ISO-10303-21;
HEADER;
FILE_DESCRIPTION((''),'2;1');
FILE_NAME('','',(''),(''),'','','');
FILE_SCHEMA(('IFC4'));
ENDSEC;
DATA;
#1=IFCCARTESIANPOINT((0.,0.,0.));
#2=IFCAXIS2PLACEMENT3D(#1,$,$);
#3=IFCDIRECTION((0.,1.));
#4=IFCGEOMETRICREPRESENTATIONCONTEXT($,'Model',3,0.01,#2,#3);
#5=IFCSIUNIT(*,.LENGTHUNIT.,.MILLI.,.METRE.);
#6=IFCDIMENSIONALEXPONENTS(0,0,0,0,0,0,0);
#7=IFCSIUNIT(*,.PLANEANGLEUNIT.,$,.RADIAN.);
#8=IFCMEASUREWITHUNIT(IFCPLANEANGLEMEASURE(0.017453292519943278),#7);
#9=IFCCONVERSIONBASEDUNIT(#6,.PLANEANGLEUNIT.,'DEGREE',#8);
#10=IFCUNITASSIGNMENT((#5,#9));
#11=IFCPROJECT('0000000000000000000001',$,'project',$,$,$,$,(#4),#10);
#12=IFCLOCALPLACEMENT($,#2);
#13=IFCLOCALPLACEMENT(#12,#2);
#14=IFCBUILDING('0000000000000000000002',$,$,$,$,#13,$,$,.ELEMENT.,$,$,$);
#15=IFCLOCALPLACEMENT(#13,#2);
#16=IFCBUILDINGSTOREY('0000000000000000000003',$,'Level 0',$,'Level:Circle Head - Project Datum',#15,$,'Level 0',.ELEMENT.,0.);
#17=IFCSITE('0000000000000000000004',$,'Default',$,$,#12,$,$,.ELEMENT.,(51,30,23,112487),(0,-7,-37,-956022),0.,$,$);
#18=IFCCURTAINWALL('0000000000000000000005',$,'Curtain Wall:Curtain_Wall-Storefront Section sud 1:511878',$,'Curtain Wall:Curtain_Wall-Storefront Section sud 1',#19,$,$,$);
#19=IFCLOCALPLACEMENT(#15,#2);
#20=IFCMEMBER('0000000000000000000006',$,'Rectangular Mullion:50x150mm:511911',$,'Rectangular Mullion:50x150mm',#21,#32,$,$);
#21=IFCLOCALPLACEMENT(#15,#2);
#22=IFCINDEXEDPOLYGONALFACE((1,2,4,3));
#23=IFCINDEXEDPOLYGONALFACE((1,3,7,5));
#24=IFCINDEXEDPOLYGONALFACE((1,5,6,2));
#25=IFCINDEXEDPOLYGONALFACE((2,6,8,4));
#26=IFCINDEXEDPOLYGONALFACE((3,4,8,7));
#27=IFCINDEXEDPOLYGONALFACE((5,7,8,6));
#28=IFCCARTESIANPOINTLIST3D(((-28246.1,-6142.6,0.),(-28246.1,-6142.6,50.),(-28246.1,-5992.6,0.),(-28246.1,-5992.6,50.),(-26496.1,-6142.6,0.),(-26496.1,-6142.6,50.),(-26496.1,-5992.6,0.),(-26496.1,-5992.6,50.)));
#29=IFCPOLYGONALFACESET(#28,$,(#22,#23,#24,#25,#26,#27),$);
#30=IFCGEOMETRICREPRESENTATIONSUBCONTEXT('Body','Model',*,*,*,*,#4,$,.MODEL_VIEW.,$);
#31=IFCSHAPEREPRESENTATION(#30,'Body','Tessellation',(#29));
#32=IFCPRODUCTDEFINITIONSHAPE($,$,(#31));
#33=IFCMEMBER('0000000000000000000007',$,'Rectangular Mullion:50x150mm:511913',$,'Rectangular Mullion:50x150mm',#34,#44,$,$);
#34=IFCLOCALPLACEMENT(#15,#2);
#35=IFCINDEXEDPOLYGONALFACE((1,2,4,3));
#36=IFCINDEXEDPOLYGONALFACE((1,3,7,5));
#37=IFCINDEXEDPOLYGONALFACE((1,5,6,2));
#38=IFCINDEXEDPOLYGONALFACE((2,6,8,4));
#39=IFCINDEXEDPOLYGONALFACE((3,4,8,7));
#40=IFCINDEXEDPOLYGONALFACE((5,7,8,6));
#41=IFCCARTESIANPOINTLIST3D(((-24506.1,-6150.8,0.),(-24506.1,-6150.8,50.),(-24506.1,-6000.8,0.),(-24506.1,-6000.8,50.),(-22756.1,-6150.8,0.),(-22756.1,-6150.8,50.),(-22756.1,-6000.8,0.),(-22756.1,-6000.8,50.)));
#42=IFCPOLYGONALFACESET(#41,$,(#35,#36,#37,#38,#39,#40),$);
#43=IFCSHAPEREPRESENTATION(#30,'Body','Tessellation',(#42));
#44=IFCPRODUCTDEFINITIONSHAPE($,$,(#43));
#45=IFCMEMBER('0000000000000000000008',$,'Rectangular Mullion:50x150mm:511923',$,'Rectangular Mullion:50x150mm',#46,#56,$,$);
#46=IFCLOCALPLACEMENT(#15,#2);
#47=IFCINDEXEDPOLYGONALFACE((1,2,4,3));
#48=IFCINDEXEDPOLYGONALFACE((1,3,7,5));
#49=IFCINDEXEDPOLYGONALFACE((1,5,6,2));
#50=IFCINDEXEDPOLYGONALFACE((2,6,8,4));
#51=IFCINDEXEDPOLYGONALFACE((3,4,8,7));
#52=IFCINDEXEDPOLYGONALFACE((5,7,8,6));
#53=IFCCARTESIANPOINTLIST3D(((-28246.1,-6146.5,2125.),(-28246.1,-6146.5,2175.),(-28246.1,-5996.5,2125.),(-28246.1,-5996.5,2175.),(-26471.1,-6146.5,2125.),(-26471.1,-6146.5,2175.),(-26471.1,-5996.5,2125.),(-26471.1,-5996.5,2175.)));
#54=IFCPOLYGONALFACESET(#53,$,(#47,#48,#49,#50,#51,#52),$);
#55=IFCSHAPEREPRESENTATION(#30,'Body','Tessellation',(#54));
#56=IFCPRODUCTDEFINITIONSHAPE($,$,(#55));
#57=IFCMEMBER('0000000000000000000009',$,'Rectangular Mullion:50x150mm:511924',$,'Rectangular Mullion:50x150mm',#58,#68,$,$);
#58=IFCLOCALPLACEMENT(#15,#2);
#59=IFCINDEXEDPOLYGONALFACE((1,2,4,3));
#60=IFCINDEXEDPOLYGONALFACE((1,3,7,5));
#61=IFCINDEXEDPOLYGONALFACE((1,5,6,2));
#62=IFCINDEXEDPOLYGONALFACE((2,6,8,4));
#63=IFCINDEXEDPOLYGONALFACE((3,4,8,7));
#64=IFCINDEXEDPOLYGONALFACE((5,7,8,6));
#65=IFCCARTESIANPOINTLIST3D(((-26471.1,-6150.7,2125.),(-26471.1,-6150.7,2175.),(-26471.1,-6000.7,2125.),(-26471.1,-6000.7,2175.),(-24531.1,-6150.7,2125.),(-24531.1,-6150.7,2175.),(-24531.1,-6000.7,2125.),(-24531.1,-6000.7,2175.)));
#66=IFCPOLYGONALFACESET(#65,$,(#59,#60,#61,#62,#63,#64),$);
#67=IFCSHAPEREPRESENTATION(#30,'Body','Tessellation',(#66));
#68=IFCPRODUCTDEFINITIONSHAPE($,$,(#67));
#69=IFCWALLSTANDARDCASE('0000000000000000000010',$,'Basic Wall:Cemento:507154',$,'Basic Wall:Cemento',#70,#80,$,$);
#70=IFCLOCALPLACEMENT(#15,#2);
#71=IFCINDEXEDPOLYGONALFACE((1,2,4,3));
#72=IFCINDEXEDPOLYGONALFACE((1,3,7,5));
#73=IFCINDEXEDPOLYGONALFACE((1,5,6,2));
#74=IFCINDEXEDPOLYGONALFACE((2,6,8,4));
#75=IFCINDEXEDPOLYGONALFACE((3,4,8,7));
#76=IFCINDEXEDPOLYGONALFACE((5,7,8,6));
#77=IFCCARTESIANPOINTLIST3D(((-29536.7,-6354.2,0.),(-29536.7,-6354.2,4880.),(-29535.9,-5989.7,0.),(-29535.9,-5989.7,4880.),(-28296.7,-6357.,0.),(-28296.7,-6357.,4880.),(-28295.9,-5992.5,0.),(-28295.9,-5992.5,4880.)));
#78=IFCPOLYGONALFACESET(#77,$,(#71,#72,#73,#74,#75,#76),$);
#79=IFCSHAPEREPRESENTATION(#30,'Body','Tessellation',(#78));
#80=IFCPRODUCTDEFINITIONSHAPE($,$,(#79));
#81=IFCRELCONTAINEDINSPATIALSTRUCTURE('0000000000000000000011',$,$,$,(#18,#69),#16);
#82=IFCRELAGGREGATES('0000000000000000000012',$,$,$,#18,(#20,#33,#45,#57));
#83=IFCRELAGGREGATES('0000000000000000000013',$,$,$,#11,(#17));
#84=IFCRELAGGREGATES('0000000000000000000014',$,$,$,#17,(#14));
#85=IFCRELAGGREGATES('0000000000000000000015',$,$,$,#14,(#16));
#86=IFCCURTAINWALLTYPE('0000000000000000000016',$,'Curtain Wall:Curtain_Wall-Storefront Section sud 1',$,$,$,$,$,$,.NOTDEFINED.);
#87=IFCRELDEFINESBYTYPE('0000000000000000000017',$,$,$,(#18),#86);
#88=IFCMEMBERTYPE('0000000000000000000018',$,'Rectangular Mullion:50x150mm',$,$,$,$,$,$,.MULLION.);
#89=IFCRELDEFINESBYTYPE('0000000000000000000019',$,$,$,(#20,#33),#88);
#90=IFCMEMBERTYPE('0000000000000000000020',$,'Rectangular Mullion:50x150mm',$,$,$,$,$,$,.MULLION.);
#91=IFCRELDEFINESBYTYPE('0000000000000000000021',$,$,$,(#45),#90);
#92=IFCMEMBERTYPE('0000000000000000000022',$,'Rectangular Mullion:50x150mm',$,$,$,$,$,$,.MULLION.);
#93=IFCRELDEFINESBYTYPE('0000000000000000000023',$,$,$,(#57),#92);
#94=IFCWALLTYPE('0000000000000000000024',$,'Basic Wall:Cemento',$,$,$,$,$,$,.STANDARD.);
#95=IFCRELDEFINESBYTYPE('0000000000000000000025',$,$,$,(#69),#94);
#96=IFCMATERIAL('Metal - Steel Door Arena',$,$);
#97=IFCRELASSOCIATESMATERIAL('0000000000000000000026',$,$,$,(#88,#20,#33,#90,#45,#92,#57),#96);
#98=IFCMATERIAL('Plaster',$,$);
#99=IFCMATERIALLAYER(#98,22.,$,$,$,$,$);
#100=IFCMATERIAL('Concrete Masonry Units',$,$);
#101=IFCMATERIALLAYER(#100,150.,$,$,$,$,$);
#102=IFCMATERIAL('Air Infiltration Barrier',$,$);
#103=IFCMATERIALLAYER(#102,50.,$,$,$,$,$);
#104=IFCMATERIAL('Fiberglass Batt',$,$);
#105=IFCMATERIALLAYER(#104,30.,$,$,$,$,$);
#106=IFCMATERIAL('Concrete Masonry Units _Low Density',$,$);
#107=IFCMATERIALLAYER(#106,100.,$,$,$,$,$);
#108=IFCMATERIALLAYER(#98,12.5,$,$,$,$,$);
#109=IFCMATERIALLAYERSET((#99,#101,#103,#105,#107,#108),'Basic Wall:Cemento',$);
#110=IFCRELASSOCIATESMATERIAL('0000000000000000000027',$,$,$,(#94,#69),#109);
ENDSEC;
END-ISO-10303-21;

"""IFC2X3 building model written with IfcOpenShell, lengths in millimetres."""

from ifc_helpers import new_model, entity, si_unit, converted_unit, direction, frame, frame_2d, origin, origin_2d_with_axis, place, context, subcontext, project, spatial, rectangle, extrude, source, transform, mapped, material, layer, layer_set, layer_usage, type_object, type_shapes, element, aggregate, save


model = new_model("IFC2X3")

# Units and contexts
model_context = context("Model", 3, precision=0.01, world=origin(), true_north=direction((0.0, 1.0)))
body_context = subcontext(model_context, "Body", "Model", "MODEL_VIEW")
ifc_project = project(units=[si_unit("LENGTHUNIT", "METRE", prefix="MILLI"), converted_unit("PLANEANGLEUNIT", "DEGREE", entity("IfcPlaneAngleMeasure", 0.017453292519943278), si_unit("PLANEANGLEUNIT", "RADIAN"), dimensions=[0, 0, 0, 0, 0, 0, 0])], contexts=[model_context])

# Site, building, storey
site_placement = place(None, origin())
site = spatial("IfcSite", under=ifc_project, at=site_placement, Name="Default", CompositionType="ELEMENT", RefLatitude=(51, 30, 23, 112487), RefLongitude=(0, -7, -37, -956022), RefElevation=0.0)
building_placement = place(site_placement, origin())
building = spatial("IfcBuilding", under=site, at=building_placement, CompositionType="ELEMENT")
storey_placement = place(building_placement, origin())
storey = spatial("IfcBuildingStorey", under=building, at=storey_placement, Name="Level 0", ObjectType="Level:Circle Head - Project Datum", LongName="Level 0", CompositionType="ELEMENT", Elevation=0.0)

# Shared definitions
curtain_wall_type = type_object("IfcCurtainWallType", Name="Curtain Wall:Curtain_Wall-Storefront Section sud 1", PredefinedType="NOTDEFINED")
ifc_material_1 = material(Name="Metal - Steel Door Arena")

# Curtain wall
curtain_wall_1_placement = place(storey_placement, origin())
curtain_wall_1 = element("IfcCurtainWall", 1, at=curtain_wall_1_placement, inside=storey, type_object=curtain_wall_type, Name="Curtain Wall:Curtain_Wall-Storefront Section sud 1:511878", ObjectType="Curtain Wall:Curtain_Wall-Storefront Section sud 1")

# Members
member_type_1 = type_object("IfcMemberType", Name="Rectangular Mullion:50x150mm", PredefinedType="MULLION", material=ifc_material_1)
shared_shape_1 = source(origin(), body_context, "Body", "SweptSolid", [
    extrude(rectangle(XDim=50.0, YDim=150.0, at=origin_2d_with_axis()), frame((-25.0, 0.0, -1750.0), z_axis=(0.0, 0.0, 1.0), x_axis=(-1.0, 0.0, 0.0)), (0.0, 0.0, 1.0), 1750.0),
])
type_shapes(member_type_1, [shared_shape_1])
member_1_placement = place(curtain_wall_1_placement, frame((-28246.1, -6067.6, 0.0), z_axis=(-1.0, 0.0, 0.0), x_axis=(0.0, 0.0, -1.0)))
member_1 = element("IfcMember", 2, at=member_1_placement, type_object=member_type_1, material=ifc_material_1, Name="Rectangular Mullion:50x150mm:511911", ObjectType="Rectangular Mullion:50x150mm", context=body_context, shape_type="MappedRepresentation", body=[
    mapped(shared_shape_1, transform((0.0, 0.0, 0.0), scale=1.0)),
])
member_2_placement = place(curtain_wall_1_placement, frame((-24506.1, -6075.8, 0.0), z_axis=(-1.0, 0.0, 0.0), x_axis=(0.0, 0.0, -1.0)))
member_2 = element("IfcMember", 3, at=member_2_placement, type_object=member_type_1, material=ifc_material_1, Name="Rectangular Mullion:50x150mm:511913", ObjectType="Rectangular Mullion:50x150mm", context=body_context, shape_type="MappedRepresentation", body=[
    mapped(shared_shape_1, transform((0.0, 0.0, 0.0), scale=1.0)),
])
member_type_2 = type_object("IfcMemberType", Name="Rectangular Mullion:50x150mm", PredefinedType="MULLION", material=ifc_material_1)
shared_shape_2 = source(origin(), body_context, "Body", "SweptSolid", [
    extrude(rectangle(XDim=50.0, YDim=150.0, at=origin_2d_with_axis()), frame((0.0, 0.0, -1775.0), z_axis=(0.0, 0.0, 1.0), x_axis=(-1.0, 0.0, 0.0)), (0.0, 0.0, 1.0), 1775.0),
])
type_shapes(member_type_2, [shared_shape_2])
member_3_placement = place(curtain_wall_1_placement, frame((-26471.1, -6071.5, 2150.0), z_axis=(1.0, 0.0, 0.0), x_axis=(0.0, 0.0, 1.0)))
member_3 = element("IfcMember", 4, at=member_3_placement, type_object=member_type_2, material=ifc_material_1, Name="Rectangular Mullion:50x150mm:511923", ObjectType="Rectangular Mullion:50x150mm", context=body_context, shape_type="MappedRepresentation", body=[
    mapped(shared_shape_2, transform((0.0, 0.0, 0.0), scale=1.0)),
])
member_type_3 = type_object("IfcMemberType", Name="Rectangular Mullion:50x150mm", PredefinedType="MULLION", material=ifc_material_1)
shared_shape_3 = source(origin(), body_context, "Body", "SweptSolid", [
    extrude(rectangle(XDim=50.0, YDim=150.0, at=origin_2d_with_axis()), frame((0.0, 0.0, -1940.0), z_axis=(0.0, 0.0, 1.0), x_axis=(-1.0, 0.0, 0.0)), (0.0, 0.0, 1.0), 1940.0),
])
type_shapes(member_type_3, [shared_shape_3])
member_4_placement = place(curtain_wall_1_placement, frame((-24531.1, -6075.7, 2150.0), z_axis=(1.0, 0.0, 0.0), x_axis=(0.0, 0.0, 1.0)))
member_4 = element("IfcMember", 5, at=member_4_placement, type_object=member_type_3, material=ifc_material_1, Name="Rectangular Mullion:50x150mm:511924", ObjectType="Rectangular Mullion:50x150mm", context=body_context, shape_type="MappedRepresentation", body=[
    mapped(shared_shape_3, transform((0.0, 0.0, 0.0), scale=1.0)),
])

aggregate(curtain_wall_1, [member_1, member_2, member_3, member_4])

# Wall
ifc_material_2 = material(Name="Plaster")
ifc_layer_1 = layer(ifc_material_2, 22.0)
ifc_material_3 = material(Name="Concrete Masonry Units")
ifc_layer_2 = layer(ifc_material_3, 150.0)
ifc_material_4 = material(Name="Air Infiltration Barrier")
ifc_layer_3 = layer(ifc_material_4, 50.0)
ifc_material_5 = material(Name="Fiberglass Batt")
ifc_layer_4 = layer(ifc_material_5, 30.0)
ifc_material_6 = material(Name="Concrete Masonry Units _Low Density")
ifc_layer_5 = layer(ifc_material_6, 100.0)
ifc_layer_6 = layer(ifc_material_2, 12.5)
ifc_layer_set = layer_set([ifc_layer_1, ifc_layer_2, ifc_layer_3, ifc_layer_4, ifc_layer_5, ifc_layer_6], Name="Basic Wall:Cemento")
ifc_layer_usage = layer_usage(ifc_layer_set, "AXIS2", "NEGATIVE", 182.3)
wall_type = type_object("IfcWallType", Name="Basic Wall:Cemento", PredefinedType="STANDARD", material=ifc_layer_set)
wall_placement = place(storey_placement, frame((-28296.3, -6174.7, 0.0), z_axis=(0.0, 0.0, 1.0), x_axis=(-0.999998, 0.002199, 0.0)))
element("IfcWallStandardCase", 6, at=wall_placement, inside=storey, type_object=wall_type, material=ifc_layer_usage, Name="Basic Wall:Cemento:507154", ObjectType="Basic Wall:Cemento", context=body_context, shape_type="SweptSolid", body=[
    extrude(rectangle(XDim=1240.0, YDim=364.5, at=frame_2d((620.0, 0.0), x_axis=(-1.0, 0.0))), origin(), (0.0, 0.0, 1.0), 4880.0),
])

save(model, "model.ifc")
